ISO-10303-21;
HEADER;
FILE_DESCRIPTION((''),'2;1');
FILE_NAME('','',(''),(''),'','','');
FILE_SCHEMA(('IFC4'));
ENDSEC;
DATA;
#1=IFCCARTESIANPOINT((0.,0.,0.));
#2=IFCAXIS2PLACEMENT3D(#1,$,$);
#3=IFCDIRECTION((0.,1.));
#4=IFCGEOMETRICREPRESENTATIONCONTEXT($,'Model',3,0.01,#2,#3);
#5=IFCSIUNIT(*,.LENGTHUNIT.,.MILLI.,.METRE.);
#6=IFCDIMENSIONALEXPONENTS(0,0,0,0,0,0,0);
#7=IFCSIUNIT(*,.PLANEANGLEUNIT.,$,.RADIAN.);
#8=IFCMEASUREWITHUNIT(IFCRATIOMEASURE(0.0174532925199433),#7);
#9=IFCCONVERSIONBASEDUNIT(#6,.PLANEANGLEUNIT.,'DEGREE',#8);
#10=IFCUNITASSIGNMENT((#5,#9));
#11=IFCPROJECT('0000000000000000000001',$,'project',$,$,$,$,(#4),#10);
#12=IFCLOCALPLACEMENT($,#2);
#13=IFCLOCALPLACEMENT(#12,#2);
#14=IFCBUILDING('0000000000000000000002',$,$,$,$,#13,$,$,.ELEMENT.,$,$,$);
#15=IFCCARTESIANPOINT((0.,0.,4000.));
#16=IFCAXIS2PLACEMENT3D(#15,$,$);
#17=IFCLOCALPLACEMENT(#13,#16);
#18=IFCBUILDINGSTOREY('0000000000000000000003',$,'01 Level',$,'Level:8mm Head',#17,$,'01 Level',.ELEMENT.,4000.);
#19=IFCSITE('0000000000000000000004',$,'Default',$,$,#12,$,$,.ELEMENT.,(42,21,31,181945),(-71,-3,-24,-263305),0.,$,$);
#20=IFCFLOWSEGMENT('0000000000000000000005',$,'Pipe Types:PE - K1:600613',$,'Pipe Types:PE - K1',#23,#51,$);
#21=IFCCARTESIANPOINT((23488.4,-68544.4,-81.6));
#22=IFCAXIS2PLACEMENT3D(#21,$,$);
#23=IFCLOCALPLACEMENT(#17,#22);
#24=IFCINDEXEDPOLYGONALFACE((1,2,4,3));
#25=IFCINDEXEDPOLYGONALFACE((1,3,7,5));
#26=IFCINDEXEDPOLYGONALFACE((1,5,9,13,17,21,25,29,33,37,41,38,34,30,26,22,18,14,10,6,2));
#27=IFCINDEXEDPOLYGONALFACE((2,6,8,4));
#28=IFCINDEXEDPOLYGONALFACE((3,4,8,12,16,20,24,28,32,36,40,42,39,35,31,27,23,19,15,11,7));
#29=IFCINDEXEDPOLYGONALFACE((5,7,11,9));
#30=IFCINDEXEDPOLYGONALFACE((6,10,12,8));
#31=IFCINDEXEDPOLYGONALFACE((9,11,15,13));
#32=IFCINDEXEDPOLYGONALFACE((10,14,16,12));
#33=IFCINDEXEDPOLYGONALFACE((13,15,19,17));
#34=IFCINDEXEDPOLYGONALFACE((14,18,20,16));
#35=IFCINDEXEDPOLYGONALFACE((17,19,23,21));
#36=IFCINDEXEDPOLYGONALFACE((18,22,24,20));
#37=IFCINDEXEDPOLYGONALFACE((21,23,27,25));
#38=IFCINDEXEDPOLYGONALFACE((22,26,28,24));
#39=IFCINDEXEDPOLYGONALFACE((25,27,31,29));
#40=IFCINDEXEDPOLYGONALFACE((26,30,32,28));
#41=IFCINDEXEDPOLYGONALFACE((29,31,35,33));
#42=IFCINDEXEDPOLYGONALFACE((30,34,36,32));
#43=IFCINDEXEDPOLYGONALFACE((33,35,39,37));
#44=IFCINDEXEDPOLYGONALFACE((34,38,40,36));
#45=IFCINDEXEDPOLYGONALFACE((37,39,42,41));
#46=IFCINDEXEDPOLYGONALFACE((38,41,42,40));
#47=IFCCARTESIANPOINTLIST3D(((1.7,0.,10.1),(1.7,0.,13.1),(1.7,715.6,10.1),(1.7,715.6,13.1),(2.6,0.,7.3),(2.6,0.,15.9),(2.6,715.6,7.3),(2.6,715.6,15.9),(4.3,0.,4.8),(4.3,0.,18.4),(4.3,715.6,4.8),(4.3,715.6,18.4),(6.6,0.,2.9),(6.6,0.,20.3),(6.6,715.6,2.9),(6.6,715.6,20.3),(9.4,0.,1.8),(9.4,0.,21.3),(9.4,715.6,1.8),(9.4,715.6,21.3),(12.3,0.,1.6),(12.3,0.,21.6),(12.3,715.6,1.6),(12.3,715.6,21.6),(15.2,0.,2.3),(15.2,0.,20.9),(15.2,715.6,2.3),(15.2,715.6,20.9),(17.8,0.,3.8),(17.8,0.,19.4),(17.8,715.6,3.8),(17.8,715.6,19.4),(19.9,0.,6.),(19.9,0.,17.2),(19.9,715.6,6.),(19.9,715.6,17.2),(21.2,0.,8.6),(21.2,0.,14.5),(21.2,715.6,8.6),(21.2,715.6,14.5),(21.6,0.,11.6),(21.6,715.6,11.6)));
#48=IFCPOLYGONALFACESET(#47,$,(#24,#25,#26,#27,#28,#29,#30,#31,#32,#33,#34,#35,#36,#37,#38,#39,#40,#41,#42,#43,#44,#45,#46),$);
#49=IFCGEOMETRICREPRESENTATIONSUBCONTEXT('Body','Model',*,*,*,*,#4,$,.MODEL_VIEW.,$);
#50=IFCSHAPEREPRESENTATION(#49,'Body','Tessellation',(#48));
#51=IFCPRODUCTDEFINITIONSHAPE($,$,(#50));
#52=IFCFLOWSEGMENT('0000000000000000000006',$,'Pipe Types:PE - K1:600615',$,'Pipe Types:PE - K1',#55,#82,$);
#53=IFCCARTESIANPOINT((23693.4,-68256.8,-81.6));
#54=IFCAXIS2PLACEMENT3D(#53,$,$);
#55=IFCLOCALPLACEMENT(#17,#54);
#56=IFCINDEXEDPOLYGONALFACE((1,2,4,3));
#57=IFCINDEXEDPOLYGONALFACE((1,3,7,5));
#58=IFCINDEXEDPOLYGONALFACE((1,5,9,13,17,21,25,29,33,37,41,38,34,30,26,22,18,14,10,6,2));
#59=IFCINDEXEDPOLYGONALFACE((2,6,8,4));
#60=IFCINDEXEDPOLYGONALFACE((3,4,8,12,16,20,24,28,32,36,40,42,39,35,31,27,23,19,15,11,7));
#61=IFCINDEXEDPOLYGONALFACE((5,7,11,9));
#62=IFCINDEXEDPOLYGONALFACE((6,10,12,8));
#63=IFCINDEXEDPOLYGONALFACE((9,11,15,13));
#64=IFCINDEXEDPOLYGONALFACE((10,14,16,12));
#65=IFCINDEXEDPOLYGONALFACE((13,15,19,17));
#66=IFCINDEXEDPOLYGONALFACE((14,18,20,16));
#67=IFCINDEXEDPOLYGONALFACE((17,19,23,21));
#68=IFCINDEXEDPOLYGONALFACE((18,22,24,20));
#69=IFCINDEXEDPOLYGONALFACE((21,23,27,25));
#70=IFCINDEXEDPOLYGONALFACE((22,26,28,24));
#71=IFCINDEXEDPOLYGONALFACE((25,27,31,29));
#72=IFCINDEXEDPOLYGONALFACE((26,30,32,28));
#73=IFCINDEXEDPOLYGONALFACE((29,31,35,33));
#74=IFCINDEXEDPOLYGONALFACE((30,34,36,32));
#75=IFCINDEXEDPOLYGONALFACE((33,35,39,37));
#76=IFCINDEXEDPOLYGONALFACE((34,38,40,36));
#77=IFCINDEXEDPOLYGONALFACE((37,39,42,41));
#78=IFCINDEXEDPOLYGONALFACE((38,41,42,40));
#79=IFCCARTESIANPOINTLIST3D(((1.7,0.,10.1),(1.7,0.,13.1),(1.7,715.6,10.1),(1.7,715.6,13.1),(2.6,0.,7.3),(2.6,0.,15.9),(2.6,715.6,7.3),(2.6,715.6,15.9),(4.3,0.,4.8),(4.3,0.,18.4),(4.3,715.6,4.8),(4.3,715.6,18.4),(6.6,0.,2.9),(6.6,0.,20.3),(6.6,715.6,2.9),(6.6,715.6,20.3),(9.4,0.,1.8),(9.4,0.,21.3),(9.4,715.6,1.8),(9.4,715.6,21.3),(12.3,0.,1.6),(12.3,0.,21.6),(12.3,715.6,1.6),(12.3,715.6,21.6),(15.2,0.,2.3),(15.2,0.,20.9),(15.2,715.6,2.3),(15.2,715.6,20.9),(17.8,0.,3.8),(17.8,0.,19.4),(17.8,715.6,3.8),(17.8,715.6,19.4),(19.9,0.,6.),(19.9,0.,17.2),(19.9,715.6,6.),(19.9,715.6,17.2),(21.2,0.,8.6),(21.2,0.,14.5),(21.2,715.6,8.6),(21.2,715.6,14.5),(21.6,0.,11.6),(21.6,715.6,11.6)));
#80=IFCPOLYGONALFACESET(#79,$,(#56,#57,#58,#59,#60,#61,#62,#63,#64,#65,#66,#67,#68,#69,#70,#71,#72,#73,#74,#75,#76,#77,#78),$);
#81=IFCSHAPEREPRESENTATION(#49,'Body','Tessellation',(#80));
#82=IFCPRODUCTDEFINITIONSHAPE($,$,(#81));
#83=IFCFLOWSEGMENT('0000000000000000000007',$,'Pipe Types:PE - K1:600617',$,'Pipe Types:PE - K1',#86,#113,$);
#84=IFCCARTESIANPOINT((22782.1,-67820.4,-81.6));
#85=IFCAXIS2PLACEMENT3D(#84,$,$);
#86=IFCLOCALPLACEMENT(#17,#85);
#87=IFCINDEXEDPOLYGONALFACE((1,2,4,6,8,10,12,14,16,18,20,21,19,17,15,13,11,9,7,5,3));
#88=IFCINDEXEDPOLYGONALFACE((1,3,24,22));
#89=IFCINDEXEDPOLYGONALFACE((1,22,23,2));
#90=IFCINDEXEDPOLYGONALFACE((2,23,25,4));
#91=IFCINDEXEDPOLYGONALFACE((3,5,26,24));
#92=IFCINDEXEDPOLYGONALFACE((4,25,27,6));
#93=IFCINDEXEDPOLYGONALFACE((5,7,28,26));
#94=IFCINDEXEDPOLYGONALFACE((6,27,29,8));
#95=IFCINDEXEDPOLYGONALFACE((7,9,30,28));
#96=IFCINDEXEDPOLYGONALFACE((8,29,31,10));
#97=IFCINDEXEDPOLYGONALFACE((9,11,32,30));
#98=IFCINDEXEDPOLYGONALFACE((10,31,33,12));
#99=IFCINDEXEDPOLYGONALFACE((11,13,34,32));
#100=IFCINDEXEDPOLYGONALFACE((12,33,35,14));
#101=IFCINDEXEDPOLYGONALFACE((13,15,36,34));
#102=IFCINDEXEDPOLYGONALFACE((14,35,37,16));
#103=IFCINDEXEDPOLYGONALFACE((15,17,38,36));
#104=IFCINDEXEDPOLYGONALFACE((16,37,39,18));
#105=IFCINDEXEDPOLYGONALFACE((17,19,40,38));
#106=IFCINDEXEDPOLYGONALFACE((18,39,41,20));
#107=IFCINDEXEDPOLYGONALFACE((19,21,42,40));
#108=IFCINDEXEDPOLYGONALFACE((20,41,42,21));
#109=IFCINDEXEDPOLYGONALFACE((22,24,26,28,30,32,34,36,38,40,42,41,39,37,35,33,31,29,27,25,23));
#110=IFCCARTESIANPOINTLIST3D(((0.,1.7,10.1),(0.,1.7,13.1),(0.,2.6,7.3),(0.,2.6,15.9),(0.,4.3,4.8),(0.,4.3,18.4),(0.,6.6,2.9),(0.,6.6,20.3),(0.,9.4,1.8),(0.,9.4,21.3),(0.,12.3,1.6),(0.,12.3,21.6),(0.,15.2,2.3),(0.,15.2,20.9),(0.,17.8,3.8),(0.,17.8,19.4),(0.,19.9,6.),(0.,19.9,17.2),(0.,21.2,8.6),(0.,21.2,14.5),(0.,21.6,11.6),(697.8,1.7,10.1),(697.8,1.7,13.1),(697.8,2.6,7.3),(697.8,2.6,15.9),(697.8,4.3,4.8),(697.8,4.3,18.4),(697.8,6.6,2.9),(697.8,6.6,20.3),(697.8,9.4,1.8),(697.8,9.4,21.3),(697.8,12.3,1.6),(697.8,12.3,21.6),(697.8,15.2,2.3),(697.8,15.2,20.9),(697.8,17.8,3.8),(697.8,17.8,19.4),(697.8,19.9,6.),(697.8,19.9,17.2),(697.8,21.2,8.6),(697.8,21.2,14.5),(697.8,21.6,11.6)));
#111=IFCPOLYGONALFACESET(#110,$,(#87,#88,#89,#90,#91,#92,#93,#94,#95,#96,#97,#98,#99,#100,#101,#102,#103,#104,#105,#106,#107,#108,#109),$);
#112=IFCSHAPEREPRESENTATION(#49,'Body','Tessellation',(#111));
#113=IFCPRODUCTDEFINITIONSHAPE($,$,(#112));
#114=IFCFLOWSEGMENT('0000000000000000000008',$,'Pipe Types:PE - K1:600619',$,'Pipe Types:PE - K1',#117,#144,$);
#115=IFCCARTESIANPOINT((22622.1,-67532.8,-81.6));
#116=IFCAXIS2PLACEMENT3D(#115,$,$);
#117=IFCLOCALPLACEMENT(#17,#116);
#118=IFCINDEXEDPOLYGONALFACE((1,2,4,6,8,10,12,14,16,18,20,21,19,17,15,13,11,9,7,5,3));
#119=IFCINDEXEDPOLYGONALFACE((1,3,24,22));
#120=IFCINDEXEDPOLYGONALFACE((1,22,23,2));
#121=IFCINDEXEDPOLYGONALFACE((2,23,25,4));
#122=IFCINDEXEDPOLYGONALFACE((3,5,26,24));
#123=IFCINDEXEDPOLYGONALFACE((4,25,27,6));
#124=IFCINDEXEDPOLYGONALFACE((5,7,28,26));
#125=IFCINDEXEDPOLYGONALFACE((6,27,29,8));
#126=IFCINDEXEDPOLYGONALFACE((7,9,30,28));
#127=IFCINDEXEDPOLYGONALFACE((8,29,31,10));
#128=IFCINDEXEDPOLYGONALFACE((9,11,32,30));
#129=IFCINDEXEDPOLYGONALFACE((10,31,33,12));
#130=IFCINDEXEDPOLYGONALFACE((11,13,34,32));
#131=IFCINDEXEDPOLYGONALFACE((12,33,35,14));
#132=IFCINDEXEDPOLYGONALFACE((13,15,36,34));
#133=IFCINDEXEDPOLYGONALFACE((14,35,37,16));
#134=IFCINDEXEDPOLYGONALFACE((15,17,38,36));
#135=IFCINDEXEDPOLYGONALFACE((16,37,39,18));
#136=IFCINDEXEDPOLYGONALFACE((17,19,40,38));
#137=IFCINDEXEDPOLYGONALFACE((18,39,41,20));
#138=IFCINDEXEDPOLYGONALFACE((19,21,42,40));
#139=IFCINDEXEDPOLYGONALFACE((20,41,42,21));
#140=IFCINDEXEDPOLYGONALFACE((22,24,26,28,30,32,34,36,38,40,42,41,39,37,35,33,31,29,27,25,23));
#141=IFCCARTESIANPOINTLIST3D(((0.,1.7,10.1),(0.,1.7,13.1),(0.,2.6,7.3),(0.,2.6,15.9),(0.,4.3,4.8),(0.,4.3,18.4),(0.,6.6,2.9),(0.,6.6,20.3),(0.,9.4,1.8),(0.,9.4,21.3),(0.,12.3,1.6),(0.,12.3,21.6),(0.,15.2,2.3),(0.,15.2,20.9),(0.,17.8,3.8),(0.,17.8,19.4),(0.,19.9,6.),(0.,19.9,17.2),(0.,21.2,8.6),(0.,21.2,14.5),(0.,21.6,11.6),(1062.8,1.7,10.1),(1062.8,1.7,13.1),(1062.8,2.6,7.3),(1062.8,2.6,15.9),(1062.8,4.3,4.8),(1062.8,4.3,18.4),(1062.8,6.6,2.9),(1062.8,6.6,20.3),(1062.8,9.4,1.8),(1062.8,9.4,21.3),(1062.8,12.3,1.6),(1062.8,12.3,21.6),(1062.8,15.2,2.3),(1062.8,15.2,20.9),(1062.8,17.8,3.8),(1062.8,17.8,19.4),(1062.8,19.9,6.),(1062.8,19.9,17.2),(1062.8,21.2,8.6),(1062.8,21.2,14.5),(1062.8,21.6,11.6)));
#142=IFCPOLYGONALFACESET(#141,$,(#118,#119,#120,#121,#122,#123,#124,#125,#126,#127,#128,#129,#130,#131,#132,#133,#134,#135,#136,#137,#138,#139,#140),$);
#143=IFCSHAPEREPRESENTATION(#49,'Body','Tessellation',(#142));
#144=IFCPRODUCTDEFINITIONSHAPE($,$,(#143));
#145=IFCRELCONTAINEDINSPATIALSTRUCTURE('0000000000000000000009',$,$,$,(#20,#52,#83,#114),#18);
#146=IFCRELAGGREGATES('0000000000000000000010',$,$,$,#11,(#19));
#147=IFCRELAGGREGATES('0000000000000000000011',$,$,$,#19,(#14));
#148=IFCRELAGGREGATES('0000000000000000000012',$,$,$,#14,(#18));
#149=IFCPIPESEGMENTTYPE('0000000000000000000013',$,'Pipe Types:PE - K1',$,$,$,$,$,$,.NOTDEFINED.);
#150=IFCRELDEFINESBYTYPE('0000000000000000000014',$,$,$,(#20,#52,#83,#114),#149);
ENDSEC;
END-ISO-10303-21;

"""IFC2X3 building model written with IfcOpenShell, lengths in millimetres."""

from ifc_helpers import new_model, entity, si_unit, converted_unit, direction, frame, frame_2d, origin, origin_2d_with_axis, place, context, subcontext, project, spatial, circle, extrude, type_object, element, save


model = new_model("IFC2X3")

# Units and contexts
model_context = context("Model", 3, precision=0.01, world=origin(), true_north=direction((0.0, 1.0)))
body_context = subcontext(model_context, "Body", "Model", "MODEL_VIEW")
ifc_project = project(units=[si_unit("LENGTHUNIT", "METRE", prefix="MILLI"), converted_unit("PLANEANGLEUNIT", "DEGREE", entity("IfcRatioMeasure", 0.0174532925199433), si_unit("PLANEANGLEUNIT", "RADIAN"), dimensions=[0, 0, 0, 0, 0, 0, 0])], contexts=[model_context])

# Site, building, storey
site_placement = place(None, origin())
site = spatial("IfcSite", under=ifc_project, at=site_placement, Name="Default", CompositionType="ELEMENT", RefLatitude=(42, 21, 31, 181945), RefLongitude=(-71, -3, -24, -263305), RefElevation=0.0)
building_placement = place(site_placement, origin())
building = spatial("IfcBuilding", under=site, at=building_placement, CompositionType="ELEMENT")
storey_placement = place(building_placement, frame((0.0, 0.0, 4000.0)))
storey = spatial("IfcBuildingStorey", under=building, at=storey_placement, Name="01 Level", ObjectType="Level:8mm Head", LongName="01 Level", CompositionType="ELEMENT", Elevation=4000.0)

# Flow segments
pipe_segment_type = type_object("IfcPipeSegmentType", Name="Pipe Types:PE - K1", PredefinedType="NOTDEFINED")
flow_segment_1_placement = place(storey_placement, frame((23488.4, -68544.4, -81.6)))
element("IfcFlowSegment", 1, at=flow_segment_1_placement, inside=storey, type_object=pipe_segment_type, Name="Pipe Types:PE - K1:600613", ObjectType="Pipe Types:PE - K1", context=body_context, shape_type="SweptSolid", body=[
    extrude(circle(Radius=10.0, at=origin_2d_with_axis()), frame((11.6, 0.0, 11.6), z_axis=(0.0, 1.0, 0.0), x_axis=(1.0, 0.0, 0.0)), (0.0, 0.0, 1.0), 715.6),
])
flow_segment_2_placement = place(storey_placement, frame((23693.4, -68256.8, -81.6)))
element("IfcFlowSegment", 2, at=flow_segment_2_placement, inside=storey, type_object=pipe_segment_type, Name="Pipe Types:PE - K1:600615", ObjectType="Pipe Types:PE - K1", context=body_context, shape_type="SweptSolid", body=[
    extrude(circle(Radius=10.0, at=origin_2d_with_axis()), frame((11.6, 0.0, 11.6), z_axis=(0.0, 1.0, 0.0), x_axis=(1.0, 0.0, 0.0)), (0.0, 0.0, 1.0), 715.6),
])
flow_segment_3_placement = place(storey_placement, frame((22782.1, -67820.4, -81.6)))
element("IfcFlowSegment", 3, at=flow_segment_3_placement, inside=storey, type_object=pipe_segment_type, Name="Pipe Types:PE - K1:600617", ObjectType="Pipe Types:PE - K1", context=body_context, shape_type="SweptSolid", body=[
    extrude(circle(Radius=10.0, at=frame_2d((0.0, 0.0), x_axis=(1.0, 0.0))), frame((0.0, 11.6, 11.6), z_axis=(1.0, 0.0, 0.0), x_axis=(0.0, 1.0, 0.0)), (0.0, 0.0, 1.0), 697.8),
])
flow_segment_4_placement = place(storey_placement, frame((22622.1, -67532.8, -81.6)))
element("IfcFlowSegment", 4, at=flow_segment_4_placement, inside=storey, type_object=pipe_segment_type, Name="Pipe Types:PE - K1:600619", ObjectType="Pipe Types:PE - K1", context=body_context, shape_type="SweptSolid", body=[
    extrude(circle(Radius=10.0, at=origin_2d_with_axis()), frame((0.0, 11.6, 11.6), z_axis=(1.0, 0.0, 0.0), x_axis=(0.0, 1.0, 0.0)), (0.0, 0.0, 1.0), 1062.8),
])

save(model, "model.ifc")
